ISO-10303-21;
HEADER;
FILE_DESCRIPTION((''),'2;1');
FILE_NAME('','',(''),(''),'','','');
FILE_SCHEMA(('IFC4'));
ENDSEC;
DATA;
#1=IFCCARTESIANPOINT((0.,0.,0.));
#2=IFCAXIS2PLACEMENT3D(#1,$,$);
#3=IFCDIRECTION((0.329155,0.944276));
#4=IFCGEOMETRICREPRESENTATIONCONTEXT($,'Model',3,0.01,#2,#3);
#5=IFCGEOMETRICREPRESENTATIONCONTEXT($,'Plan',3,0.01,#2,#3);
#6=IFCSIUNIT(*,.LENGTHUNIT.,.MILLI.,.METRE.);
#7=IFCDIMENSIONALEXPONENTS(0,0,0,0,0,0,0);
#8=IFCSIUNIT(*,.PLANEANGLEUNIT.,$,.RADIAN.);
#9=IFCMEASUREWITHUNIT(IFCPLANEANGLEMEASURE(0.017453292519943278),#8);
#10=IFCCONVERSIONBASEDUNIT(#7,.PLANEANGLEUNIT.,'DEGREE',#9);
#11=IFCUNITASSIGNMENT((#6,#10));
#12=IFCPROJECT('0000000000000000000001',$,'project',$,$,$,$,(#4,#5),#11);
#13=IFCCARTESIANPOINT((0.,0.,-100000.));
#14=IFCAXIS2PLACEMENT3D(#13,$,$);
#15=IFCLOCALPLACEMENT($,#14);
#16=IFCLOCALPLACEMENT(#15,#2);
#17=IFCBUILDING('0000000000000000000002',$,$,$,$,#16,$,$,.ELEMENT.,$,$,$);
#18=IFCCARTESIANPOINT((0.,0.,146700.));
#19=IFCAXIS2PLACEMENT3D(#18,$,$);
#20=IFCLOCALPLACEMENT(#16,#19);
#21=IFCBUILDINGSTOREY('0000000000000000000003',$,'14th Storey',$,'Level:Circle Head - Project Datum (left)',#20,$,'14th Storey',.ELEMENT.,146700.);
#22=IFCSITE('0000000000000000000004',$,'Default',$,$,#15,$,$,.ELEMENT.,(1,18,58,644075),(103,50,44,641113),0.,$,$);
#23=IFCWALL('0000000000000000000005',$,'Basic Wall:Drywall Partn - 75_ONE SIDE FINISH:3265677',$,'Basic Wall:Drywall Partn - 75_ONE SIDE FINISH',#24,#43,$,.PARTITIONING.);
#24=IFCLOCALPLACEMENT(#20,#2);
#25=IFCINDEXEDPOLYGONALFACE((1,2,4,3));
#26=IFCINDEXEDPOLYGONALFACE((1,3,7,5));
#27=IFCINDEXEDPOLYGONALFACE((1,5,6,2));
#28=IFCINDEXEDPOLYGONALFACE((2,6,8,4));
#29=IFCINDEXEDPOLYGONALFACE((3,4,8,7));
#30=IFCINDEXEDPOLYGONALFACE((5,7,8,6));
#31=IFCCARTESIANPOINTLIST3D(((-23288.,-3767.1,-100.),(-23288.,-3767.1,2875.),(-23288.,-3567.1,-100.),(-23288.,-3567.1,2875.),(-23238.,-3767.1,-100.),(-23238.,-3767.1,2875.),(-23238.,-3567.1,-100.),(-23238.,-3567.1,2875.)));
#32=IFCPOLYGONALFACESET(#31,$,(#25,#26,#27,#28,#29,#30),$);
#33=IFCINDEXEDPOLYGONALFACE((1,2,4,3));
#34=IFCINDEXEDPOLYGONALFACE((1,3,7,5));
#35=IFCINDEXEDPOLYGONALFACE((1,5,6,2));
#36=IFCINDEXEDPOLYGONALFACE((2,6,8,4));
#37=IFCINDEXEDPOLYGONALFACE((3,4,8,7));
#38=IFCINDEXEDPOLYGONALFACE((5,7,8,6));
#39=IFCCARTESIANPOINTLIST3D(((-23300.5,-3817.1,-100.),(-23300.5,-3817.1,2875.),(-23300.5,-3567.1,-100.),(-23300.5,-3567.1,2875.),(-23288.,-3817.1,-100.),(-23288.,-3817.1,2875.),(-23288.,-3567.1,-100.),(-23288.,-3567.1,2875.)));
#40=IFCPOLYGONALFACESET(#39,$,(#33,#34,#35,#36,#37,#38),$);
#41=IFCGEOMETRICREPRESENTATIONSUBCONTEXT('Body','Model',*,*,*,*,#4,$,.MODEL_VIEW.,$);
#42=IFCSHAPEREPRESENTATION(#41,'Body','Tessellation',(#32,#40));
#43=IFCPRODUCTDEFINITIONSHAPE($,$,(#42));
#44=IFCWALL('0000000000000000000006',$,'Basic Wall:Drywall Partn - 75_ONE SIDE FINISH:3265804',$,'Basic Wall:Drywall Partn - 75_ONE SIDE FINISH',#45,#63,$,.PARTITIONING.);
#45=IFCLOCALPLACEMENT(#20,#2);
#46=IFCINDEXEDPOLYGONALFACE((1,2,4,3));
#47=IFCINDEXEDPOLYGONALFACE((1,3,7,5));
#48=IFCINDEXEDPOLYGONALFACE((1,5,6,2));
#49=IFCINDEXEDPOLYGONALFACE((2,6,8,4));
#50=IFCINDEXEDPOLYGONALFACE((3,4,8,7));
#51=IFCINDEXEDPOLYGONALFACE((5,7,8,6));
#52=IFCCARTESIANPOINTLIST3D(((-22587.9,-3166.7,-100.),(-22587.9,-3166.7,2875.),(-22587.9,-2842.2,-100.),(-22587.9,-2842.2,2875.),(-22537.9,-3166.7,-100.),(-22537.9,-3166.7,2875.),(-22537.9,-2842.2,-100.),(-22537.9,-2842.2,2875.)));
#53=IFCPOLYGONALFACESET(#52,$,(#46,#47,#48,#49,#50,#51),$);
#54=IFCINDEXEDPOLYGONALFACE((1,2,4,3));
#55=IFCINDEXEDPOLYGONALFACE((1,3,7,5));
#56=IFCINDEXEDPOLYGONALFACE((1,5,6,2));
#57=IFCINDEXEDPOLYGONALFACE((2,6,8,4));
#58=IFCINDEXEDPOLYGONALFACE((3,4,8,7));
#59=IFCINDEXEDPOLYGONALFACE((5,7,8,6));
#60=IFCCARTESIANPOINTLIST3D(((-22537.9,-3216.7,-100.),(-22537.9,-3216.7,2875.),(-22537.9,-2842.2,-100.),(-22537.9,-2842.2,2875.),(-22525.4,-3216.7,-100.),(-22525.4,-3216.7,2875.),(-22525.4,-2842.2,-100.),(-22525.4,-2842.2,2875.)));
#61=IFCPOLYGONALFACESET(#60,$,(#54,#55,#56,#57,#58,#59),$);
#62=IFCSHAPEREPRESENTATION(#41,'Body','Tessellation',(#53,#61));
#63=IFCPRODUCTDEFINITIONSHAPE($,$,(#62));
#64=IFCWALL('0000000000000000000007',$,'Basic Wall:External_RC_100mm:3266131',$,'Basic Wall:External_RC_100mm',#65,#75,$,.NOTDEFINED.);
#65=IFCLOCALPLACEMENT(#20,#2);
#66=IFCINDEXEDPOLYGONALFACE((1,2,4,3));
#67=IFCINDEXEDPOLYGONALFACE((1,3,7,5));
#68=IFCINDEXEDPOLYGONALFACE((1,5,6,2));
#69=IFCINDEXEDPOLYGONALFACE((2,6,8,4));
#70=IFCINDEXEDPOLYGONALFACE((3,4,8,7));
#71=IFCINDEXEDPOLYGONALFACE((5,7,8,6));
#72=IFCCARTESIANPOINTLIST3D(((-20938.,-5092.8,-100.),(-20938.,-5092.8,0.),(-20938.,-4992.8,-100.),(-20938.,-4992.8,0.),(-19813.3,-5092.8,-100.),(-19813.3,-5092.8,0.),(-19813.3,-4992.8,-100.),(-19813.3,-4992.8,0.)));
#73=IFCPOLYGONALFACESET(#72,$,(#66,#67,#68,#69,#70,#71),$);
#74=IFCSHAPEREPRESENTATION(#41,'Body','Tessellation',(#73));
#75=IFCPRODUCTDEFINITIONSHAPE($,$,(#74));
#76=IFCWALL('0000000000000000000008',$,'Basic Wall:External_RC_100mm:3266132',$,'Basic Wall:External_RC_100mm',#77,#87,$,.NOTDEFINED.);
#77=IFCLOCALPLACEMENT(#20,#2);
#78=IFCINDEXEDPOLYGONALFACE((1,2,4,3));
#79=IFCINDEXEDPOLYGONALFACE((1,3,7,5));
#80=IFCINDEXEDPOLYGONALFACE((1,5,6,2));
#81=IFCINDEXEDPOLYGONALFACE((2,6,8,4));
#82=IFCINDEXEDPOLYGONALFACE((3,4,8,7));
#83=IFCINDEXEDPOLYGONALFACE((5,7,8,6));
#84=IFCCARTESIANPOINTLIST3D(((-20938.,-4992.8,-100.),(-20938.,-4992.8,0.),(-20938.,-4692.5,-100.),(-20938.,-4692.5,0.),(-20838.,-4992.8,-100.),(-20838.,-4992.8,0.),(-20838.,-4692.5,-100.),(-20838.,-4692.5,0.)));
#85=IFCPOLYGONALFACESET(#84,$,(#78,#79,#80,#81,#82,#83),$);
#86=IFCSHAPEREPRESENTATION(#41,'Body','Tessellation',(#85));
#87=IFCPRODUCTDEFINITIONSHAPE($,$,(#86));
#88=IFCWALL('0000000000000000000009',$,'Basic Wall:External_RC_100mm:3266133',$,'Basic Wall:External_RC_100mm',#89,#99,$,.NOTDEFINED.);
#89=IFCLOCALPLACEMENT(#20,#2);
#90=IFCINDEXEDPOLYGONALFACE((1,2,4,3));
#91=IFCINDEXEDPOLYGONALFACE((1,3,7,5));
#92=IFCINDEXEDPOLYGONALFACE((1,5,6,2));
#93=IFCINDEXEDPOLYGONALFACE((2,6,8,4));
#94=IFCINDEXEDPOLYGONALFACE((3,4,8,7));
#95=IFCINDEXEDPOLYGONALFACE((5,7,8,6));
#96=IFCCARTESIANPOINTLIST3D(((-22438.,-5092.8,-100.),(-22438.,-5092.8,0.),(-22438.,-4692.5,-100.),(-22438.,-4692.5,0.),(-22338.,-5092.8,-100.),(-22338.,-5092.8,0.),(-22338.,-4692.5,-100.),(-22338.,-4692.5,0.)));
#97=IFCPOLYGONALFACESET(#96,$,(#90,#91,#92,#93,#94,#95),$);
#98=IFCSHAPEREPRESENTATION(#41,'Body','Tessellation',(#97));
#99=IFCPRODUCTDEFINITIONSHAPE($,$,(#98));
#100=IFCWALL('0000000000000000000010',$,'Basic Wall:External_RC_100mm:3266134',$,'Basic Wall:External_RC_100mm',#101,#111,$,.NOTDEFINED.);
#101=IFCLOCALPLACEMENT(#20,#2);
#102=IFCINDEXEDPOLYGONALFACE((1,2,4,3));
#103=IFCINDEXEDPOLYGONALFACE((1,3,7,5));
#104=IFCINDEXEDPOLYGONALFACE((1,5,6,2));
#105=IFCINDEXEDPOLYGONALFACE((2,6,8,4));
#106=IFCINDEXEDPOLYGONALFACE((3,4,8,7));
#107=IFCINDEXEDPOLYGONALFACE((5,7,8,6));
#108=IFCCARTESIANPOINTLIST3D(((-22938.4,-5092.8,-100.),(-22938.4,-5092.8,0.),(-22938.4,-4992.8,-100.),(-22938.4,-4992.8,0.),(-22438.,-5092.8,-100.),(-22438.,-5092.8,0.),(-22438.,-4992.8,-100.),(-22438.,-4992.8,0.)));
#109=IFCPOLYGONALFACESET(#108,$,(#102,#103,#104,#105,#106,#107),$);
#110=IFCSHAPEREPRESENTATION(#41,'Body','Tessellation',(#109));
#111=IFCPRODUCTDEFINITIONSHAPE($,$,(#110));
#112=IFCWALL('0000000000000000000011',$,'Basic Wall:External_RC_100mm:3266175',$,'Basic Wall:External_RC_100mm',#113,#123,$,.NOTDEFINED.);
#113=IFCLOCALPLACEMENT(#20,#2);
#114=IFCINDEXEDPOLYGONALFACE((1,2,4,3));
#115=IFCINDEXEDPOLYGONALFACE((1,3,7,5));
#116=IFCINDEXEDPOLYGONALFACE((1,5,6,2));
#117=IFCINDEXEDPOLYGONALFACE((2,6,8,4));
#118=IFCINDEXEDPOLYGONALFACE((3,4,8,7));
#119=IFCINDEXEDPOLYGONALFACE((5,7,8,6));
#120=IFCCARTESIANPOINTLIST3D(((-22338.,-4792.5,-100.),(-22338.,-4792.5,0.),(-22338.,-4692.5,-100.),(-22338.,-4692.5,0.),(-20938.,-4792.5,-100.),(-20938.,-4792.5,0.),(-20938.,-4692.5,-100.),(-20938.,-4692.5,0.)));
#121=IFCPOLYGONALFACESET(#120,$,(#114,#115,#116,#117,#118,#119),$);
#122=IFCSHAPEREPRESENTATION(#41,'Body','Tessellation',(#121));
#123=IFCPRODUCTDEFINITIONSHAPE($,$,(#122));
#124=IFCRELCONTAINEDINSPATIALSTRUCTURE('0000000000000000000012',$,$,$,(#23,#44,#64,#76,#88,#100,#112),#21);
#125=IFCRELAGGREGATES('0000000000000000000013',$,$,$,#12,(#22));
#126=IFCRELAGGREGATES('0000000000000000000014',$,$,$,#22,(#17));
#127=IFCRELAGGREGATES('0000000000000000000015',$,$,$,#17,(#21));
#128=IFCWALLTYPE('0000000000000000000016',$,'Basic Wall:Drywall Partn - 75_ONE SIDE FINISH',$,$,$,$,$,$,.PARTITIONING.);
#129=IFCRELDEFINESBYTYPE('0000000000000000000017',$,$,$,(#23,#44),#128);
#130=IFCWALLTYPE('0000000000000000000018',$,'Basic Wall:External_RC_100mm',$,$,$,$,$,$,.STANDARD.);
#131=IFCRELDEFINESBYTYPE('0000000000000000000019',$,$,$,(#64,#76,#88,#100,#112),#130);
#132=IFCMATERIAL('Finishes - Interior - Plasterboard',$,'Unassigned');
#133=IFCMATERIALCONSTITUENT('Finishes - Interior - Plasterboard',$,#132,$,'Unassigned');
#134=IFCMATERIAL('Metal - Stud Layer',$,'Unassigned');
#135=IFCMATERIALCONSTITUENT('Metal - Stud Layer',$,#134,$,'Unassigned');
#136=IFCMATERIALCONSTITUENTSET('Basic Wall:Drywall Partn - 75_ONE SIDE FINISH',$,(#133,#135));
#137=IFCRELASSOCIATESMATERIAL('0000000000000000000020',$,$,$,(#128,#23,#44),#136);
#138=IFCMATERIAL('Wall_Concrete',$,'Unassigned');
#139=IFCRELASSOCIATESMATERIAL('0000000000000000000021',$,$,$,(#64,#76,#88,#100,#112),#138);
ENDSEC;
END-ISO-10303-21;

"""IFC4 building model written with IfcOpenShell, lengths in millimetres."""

from ifc_helpers import new_model, entity, si_unit, converted_unit, direction, frame, origin, place, context, subcontext, project, spatial, indexed_curve, outline, extrude, material, constituent, constituent_set, type_object, element, save


model = new_model("IFC4")

# Units and contexts
model_context = context("Model", 3, precision=0.01, world=origin(), true_north=direction((0.329155, 0.944276)))
plan_context = context("Plan", 3, precision=0.01, world=origin(), true_north=direction((0.329155, 0.944276)))
body_context = subcontext(model_context, "Body", "Model", "MODEL_VIEW")
ifc_project = project(units=[si_unit("LENGTHUNIT", "METRE", prefix="MILLI"), converted_unit("PLANEANGLEUNIT", "DEGREE", entity("IfcPlaneAngleMeasure", 0.017453292519943278), si_unit("PLANEANGLEUNIT", "RADIAN"), dimensions=[0, 0, 0, 0, 0, 0, 0])], contexts=[model_context, plan_context])

# Site, building, storey
site_placement = place(None, frame((0.0, 0.0, -100000.0)))
site = spatial("IfcSite", under=ifc_project, at=site_placement, Name="Default", CompositionType="ELEMENT", RefLatitude=(1, 18, 58, 644075), RefLongitude=(103, 50, 44, 641113), RefElevation=0.0)
building_placement = place(site_placement, origin())
building = spatial("IfcBuilding", under=site, at=building_placement, CompositionType="ELEMENT")
storey_placement = place(building_placement, frame((0.0, 0.0, 146700.0)))
storey = spatial("IfcBuildingStorey", under=building, at=storey_placement, Name="14th Storey", ObjectType="Level:Circle Head - Project Datum (left)", LongName="14th Storey", CompositionType="ELEMENT", Elevation=146700.0)

# Walls
ifc_material_1 = material(Name="Wall_Concrete", Category="Unassigned")
ifc_material_2 = material(Name="Finishes - Interior - Plasterboard", Category="Unassigned")
ifc_constituent_1 = constituent(ifc_material_2, Name="Finishes - Interior - Plasterboard", Category="Unassigned")
ifc_material_3 = material(Name="Metal - Stud Layer", Category="Unassigned")
ifc_constituent_2 = constituent(ifc_material_3, Name="Metal - Stud Layer", Category="Unassigned")
ifc_constituent_set = constituent_set(constituents=[ifc_constituent_1, ifc_constituent_2], Name="Basic Wall:Drywall Partn - 75_ONE SIDE FINISH")
wall_type_1 = type_object("IfcWallType", Name="Basic Wall:Drywall Partn - 75_ONE SIDE FINISH", PredefinedType="PARTITIONING", material=ifc_constituent_set)
wall_1_placement = place(storey_placement, frame((-23269.2, -3567.1, -100.0), z_axis=(0.0, 0.0, 1.0), x_axis=(0.0, -1.0, 0.0)))
element("IfcWall", 1, at=wall_1_placement, inside=storey, type_object=wall_type_1, material=ifc_constituent_set, Name="Basic Wall:Drywall Partn - 75_ONE SIDE FINISH:3265677", ObjectType="Basic Wall:Drywall Partn - 75_ONE SIDE FINISH", PredefinedType="PARTITIONING", context=body_context, shape_type="SweptSolid", body=[
    extrude(outline(indexed_curve([(-25.0, -100.0), (25.0, -100.0), (25.0, 100.0), (-25.0, 100.0), (-25.0, -100.0)], self_intersect=False)), frame((100.0, 6.2, 0.0), z_axis=(0.0, 0.0, 1.0), x_axis=(0.0, -1.0, 0.0)), (0.0, 0.0, 1.0), 2975.0),
    extrude(outline(indexed_curve([(-6.2, -125.0), (6.2, -125.0), (6.2, 125.0), (-6.2, 125.0), (-6.2, -125.0)], self_intersect=False)), frame((125.0, -25.0, 0.0), z_axis=(0.0, 0.0, 1.0), x_axis=(0.0, -1.0, 0.0)), (0.0, 0.0, 1.0), 2975.0),
])
wall_2_placement = place(storey_placement, frame((-22556.6, -2842.2, -100.0), z_axis=(0.0, 0.0, 1.0), x_axis=(0.0, -1.0, 0.0)))
element("IfcWall", 2, at=wall_2_placement, inside=storey, type_object=wall_type_1, material=ifc_constituent_set, Name="Basic Wall:Drywall Partn - 75_ONE SIDE FINISH:3265804", ObjectType="Basic Wall:Drywall Partn - 75_ONE SIDE FINISH", PredefinedType="PARTITIONING", context=body_context, shape_type="SweptSolid", body=[
    extrude(outline(indexed_curve([(-25.0, -162.3), (25.0, -162.3), (25.0, 162.3), (-25.0, 162.3), (-25.0, -162.3)], self_intersect=False)), frame((162.3, -6.2, 0.0), z_axis=(0.0, 0.0, 1.0), x_axis=(0.0, 1.0, 0.0)), (0.0, 0.0, 1.0), 2975.0),
    extrude(outline(indexed_curve([(-6.3, -187.3), (6.2, -187.3), (6.2, 187.3), (-6.3, 187.3), (-6.3, -187.3)], self_intersect=False)), frame((187.3, 25.0, 0.0), z_axis=(0.0, 0.0, 1.0), x_axis=(0.0, 1.0, 0.0)), (0.0, 0.0, 1.0), 2975.0),
])
wall_type_2 = type_object("IfcWallType", Name="Basic Wall:External_RC_100mm", PredefinedType="STANDARD")
wall_3_placement = place(storey_placement, frame((-19813.3, -5042.8, -100.0), z_axis=(0.0, 0.0, 1.0), x_axis=(-1.0, 0.0, 0.0)))
element("IfcWall", 3, at=wall_3_placement, inside=storey, type_object=wall_type_2, material=ifc_material_1, Name="Basic Wall:External_RC_100mm:3266131", ObjectType="Basic Wall:External_RC_100mm", PredefinedType="NOTDEFINED", context=body_context, shape_type="SweptSolid", body=[
    extrude(outline(indexed_curve([(1124.6, 50.0), (0.0, 50.0), (0.0, -50.0), (1124.6, -50.0), (1124.6, 50.0)], self_intersect=False)), origin(), (0.0, 0.0, 1.0), 100.0),
])
wall_4_placement = place(storey_placement, frame((-20888.0, -4992.8, -100.0), z_axis=(0.0, 0.0, 1.0), x_axis=(0.0, 1.0, 0.0)))
element("IfcWall", 4, at=wall_4_placement, inside=storey, type_object=wall_type_2, material=ifc_material_1, Name="Basic Wall:External_RC_100mm:3266132", ObjectType="Basic Wall:External_RC_100mm", PredefinedType="NOTDEFINED", context=body_context, shape_type="SweptSolid", body=[
    extrude(outline(indexed_curve([(300.3, 50.0), (0.0, 50.0), (0.0, -50.0), (300.3, -50.0), (300.3, 50.0)], self_intersect=False)), origin(), (0.0, 0.0, 1.0), 100.0),
])
wall_5_placement = place(storey_placement, frame((-22388.0, -4692.5, -100.0), z_axis=(0.0, 0.0, 1.0), x_axis=(0.0, -1.0, 0.0)))
element("IfcWall", 5, at=wall_5_placement, inside=storey, type_object=wall_type_2, material=ifc_material_1, Name="Basic Wall:External_RC_100mm:3266133", ObjectType="Basic Wall:External_RC_100mm", PredefinedType="NOTDEFINED", context=body_context, shape_type="SweptSolid", body=[
    extrude(outline(indexed_curve([(400.3, 50.0), (0.0, 50.0), (0.0, -50.0), (400.3, -50.0), (400.3, 50.0)], self_intersect=False)), origin(), (0.0, 0.0, 1.0), 100.0),
])
wall_6_placement = place(storey_placement, frame((-22438.0, -5042.8, -100.0), z_axis=(0.0, 0.0, 1.0), x_axis=(-1.0, 0.0, 0.0)))
element("IfcWall", 6, at=wall_6_placement, inside=storey, type_object=wall_type_2, material=ifc_material_1, Name="Basic Wall:External_RC_100mm:3266134", ObjectType="Basic Wall:External_RC_100mm", PredefinedType="NOTDEFINED", context=body_context, shape_type="SweptSolid", body=[
    extrude(outline(indexed_curve([(500.4, 50.0), (0.0, 50.0), (0.0, -50.0), (500.4, -50.0), (500.4, 50.0)], self_intersect=False)), origin(), (0.0, 0.0, 1.0), 100.0),
])
wall_7_placement = place(storey_placement, frame((-20938.0, -4742.5, -100.0), z_axis=(0.0, 0.0, 1.0), x_axis=(-1.0, 0.0, 0.0)))
element("IfcWall", 7, at=wall_7_placement, inside=storey, type_object=wall_type_2, material=ifc_material_1, Name="Basic Wall:External_RC_100mm:3266175", ObjectType="Basic Wall:External_RC_100mm", PredefinedType="NOTDEFINED", context=body_context, shape_type="SweptSolid", body=[
    extrude(outline(indexed_curve([(1400.0, 50.0), (0.0, 50.0), (0.0, -50.0), (1400.0, -50.0), (1400.0, 50.0)], self_intersect=False)), origin(), (0.0, 0.0, 1.0), 100.0),
])

save(model, "model.ifc")
